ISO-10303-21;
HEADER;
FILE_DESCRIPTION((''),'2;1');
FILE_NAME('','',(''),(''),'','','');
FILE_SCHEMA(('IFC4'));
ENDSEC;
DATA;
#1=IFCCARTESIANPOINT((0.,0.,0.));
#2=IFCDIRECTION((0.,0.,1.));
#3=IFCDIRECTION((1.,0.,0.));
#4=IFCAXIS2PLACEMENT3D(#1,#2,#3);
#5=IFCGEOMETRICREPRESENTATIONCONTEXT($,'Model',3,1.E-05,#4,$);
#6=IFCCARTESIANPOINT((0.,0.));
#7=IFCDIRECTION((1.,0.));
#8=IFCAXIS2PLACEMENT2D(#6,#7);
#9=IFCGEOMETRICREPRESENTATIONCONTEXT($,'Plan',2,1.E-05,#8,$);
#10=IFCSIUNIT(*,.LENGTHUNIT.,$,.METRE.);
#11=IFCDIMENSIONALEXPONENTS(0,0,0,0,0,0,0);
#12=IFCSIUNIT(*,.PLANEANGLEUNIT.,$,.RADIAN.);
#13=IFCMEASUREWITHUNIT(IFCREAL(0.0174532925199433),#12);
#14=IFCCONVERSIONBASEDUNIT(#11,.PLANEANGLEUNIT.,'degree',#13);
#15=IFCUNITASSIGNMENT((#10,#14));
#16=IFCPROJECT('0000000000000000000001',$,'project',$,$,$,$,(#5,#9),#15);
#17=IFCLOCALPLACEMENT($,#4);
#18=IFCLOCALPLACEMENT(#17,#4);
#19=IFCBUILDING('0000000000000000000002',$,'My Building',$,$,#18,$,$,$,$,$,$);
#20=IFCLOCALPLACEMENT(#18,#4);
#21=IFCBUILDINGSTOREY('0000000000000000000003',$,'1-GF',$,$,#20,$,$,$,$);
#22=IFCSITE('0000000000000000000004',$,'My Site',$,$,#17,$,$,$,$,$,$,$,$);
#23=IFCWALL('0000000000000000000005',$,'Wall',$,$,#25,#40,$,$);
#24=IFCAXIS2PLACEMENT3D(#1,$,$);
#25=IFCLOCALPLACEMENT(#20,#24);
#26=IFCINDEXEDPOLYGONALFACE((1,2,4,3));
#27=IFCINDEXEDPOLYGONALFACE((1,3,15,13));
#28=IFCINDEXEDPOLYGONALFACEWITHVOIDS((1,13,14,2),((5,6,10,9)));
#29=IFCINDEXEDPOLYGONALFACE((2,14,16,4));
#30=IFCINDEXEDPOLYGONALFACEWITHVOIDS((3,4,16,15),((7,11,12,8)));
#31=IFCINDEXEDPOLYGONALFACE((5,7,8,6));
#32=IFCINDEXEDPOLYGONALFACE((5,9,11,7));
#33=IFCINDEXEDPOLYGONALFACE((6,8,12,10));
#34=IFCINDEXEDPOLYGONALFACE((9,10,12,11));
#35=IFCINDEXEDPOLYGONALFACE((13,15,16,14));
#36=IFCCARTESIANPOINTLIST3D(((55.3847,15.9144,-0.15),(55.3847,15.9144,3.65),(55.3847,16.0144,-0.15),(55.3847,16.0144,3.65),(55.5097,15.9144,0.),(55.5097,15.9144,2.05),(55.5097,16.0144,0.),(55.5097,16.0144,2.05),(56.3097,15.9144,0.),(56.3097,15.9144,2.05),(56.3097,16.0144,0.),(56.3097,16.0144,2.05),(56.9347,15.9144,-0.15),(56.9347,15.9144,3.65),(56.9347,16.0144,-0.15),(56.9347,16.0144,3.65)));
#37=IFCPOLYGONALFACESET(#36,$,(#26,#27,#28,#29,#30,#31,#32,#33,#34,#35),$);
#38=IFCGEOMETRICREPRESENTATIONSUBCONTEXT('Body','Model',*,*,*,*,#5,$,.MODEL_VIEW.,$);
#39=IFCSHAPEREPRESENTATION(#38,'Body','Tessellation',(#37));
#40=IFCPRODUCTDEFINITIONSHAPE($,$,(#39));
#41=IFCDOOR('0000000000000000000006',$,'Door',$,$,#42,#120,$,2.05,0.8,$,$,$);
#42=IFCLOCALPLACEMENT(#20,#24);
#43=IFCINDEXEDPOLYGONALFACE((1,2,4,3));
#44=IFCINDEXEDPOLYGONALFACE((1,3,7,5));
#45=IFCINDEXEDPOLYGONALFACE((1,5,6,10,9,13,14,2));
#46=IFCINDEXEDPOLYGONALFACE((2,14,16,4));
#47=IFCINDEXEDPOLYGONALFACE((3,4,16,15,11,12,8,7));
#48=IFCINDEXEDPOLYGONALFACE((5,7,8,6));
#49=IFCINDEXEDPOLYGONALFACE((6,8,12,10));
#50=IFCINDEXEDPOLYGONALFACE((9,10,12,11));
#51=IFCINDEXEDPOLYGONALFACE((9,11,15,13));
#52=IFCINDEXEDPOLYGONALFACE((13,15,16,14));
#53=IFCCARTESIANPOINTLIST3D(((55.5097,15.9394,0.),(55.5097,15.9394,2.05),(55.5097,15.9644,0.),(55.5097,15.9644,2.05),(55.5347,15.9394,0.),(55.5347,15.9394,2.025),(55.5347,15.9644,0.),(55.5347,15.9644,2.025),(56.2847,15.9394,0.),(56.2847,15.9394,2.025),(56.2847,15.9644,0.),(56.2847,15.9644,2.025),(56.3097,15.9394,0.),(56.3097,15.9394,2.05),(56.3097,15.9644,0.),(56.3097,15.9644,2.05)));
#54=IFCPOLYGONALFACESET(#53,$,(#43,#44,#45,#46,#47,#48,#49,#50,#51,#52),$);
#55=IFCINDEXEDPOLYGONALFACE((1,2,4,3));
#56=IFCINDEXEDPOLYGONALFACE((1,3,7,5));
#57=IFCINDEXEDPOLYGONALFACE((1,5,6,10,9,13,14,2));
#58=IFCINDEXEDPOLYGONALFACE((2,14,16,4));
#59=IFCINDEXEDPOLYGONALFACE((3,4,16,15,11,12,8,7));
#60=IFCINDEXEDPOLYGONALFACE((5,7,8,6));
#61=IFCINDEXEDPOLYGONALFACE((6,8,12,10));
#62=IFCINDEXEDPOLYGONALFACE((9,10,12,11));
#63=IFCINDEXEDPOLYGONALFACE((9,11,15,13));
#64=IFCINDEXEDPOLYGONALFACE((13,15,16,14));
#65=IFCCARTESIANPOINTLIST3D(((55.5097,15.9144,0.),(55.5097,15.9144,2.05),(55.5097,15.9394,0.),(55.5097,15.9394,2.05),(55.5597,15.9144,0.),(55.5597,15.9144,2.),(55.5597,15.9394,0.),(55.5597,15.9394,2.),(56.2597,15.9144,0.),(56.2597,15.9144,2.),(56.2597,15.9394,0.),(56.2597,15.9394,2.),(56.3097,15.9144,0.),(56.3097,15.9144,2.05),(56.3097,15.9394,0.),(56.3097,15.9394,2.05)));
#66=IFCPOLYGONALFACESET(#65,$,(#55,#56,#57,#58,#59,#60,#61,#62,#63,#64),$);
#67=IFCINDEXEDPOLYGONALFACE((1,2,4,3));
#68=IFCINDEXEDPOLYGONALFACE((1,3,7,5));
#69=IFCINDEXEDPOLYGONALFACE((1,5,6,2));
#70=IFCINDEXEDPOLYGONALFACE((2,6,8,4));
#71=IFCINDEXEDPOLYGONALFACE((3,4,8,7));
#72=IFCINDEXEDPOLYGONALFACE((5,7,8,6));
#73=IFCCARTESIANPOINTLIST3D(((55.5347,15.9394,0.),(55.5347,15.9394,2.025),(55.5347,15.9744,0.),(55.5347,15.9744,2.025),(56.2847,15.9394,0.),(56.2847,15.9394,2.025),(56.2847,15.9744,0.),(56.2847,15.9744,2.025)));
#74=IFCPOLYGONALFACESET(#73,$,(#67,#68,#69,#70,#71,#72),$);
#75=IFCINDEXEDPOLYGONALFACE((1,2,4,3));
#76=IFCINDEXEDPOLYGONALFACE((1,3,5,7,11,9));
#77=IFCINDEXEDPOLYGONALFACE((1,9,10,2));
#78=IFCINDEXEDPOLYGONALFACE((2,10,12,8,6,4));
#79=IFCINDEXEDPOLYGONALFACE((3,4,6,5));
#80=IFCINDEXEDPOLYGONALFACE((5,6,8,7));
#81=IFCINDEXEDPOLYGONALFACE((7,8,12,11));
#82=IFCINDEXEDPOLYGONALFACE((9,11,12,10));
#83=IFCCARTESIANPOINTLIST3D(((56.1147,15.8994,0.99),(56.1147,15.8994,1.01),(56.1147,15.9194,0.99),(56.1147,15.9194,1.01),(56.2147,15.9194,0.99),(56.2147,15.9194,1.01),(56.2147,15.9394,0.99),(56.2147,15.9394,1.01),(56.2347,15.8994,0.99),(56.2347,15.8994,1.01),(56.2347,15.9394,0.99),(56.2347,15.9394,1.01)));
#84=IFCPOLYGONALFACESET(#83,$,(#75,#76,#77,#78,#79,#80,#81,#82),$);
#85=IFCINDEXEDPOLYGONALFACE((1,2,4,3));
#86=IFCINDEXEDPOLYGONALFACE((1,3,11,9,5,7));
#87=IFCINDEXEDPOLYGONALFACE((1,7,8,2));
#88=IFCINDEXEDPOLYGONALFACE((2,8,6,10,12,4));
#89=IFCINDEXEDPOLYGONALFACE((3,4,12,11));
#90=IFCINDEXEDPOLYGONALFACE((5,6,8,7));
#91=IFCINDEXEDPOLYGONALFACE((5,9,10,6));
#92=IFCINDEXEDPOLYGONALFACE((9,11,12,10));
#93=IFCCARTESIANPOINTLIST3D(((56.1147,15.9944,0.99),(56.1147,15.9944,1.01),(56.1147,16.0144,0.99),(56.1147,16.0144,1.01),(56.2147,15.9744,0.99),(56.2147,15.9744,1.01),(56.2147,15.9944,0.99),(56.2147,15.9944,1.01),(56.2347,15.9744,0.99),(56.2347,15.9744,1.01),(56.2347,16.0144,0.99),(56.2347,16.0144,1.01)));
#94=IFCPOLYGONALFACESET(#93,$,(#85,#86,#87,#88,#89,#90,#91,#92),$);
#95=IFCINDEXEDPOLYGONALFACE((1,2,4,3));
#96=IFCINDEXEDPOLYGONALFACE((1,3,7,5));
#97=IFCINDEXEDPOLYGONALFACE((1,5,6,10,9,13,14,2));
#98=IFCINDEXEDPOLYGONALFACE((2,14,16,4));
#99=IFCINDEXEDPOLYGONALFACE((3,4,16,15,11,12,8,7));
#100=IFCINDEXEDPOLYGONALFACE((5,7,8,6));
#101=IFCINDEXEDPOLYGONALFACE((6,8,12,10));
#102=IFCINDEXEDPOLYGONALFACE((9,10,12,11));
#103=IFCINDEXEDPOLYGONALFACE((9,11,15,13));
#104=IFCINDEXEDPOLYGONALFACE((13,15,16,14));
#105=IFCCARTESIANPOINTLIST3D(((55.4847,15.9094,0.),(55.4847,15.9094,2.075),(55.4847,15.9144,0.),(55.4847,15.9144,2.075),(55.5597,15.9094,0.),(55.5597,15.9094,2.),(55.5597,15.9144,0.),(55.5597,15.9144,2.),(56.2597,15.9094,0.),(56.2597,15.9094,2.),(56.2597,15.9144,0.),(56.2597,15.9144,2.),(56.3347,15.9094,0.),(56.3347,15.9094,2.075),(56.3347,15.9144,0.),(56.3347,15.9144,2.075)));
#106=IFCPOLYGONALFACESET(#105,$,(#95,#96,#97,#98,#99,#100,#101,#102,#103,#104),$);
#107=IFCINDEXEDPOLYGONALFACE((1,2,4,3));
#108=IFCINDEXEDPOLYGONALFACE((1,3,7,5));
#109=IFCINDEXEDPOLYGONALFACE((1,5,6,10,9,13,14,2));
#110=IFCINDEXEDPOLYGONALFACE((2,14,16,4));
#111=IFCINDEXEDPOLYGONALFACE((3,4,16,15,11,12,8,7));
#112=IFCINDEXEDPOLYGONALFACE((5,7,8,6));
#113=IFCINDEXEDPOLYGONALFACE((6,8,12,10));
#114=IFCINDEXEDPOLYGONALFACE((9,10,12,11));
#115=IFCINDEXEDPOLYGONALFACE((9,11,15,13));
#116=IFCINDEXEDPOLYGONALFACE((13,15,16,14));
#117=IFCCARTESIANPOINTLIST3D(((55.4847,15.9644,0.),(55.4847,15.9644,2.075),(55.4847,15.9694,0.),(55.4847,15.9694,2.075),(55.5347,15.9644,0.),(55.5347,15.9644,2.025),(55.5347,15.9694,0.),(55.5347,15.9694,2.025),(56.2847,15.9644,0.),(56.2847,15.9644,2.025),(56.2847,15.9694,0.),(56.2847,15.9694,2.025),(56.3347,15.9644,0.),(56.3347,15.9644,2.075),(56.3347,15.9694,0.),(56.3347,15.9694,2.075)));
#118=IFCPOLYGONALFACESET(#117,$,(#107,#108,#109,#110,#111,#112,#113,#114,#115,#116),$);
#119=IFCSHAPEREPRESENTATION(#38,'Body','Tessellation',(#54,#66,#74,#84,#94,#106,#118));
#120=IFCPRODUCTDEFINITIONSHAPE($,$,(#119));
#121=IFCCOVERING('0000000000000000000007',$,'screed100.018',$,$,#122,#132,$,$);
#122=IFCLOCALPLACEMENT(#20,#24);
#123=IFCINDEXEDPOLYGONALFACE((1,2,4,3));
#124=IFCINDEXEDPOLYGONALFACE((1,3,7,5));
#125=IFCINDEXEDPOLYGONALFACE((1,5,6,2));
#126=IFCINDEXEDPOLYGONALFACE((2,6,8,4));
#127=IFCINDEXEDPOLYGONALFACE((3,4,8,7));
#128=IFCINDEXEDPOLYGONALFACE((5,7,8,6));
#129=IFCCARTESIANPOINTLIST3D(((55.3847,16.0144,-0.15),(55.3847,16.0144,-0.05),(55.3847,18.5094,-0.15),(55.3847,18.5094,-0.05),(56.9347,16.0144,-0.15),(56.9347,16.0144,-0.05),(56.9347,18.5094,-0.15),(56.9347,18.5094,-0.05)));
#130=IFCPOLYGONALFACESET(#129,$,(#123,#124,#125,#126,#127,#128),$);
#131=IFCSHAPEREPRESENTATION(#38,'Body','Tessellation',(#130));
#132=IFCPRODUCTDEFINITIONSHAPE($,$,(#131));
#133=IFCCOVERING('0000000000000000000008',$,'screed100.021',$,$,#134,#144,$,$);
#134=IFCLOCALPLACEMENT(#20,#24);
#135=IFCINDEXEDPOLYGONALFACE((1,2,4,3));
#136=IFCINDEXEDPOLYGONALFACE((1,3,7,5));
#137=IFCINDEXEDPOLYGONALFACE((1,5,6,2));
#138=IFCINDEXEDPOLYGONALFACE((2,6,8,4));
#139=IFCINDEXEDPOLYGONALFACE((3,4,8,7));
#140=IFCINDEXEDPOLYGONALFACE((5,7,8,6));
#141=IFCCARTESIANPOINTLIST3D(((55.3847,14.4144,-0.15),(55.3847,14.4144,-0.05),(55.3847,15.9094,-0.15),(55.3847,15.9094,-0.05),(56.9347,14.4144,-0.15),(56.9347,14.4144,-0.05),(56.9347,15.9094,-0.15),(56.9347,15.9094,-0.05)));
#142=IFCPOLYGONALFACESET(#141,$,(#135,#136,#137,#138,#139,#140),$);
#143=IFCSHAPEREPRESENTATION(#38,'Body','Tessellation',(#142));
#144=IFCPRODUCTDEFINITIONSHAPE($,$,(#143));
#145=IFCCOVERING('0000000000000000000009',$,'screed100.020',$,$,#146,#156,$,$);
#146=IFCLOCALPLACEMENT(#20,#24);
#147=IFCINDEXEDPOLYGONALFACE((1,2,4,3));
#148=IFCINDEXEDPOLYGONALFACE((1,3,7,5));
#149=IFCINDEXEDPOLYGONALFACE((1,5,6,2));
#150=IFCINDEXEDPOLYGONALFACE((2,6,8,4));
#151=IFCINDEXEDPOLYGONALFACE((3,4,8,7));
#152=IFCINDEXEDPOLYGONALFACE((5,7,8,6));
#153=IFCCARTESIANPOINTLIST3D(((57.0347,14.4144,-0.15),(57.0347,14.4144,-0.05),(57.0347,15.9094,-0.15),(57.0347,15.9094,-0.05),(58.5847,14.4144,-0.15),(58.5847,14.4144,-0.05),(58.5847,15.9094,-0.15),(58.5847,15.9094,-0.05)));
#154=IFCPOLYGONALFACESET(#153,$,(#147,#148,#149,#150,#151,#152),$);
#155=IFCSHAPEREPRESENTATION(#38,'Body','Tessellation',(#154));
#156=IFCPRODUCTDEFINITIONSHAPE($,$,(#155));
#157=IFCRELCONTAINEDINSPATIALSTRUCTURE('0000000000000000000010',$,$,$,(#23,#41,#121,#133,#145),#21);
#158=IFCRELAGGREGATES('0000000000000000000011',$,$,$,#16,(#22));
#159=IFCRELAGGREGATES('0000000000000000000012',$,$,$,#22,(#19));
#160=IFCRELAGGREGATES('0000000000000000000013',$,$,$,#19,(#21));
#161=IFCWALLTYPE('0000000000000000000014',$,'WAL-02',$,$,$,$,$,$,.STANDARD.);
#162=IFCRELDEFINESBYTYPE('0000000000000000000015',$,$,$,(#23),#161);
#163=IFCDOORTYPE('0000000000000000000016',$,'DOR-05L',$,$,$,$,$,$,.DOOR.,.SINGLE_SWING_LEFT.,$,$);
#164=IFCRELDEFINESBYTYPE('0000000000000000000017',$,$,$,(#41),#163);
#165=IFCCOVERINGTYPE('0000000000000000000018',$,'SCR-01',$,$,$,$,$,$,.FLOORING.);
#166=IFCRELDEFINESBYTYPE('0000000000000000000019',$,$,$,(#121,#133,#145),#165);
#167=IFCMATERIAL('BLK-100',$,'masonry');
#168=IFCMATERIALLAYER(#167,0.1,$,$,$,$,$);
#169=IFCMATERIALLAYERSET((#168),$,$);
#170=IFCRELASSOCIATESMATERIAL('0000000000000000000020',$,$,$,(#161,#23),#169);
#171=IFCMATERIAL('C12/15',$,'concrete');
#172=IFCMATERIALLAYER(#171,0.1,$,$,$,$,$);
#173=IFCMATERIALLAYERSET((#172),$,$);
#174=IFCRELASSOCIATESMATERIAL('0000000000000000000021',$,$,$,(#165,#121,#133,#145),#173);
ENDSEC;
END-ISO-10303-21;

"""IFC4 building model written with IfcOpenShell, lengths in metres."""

from ifc_helpers import new_model, entity, si_unit, converted_unit, frame, origin_with_axes, origin_2d_with_axis, place, context, subcontext, project, spatial, line, indexed_curve, outline, extrude, shape, source, transform, mapped, material, layer, layer_set, layer_usage, type_object, type_shapes, element, fill, save


model = new_model("IFC4")

# Units and contexts
model_context = context("Model", 3, precision=1e-05, world=origin_with_axes())
plan_context = context("Plan", 2, precision=1e-05, world=origin_2d_with_axis())
body_context_1 = subcontext(model_context, "Body", "Model", "MODEL_VIEW")
body_context_2 = subcontext(plan_context, "Body", "Plan", "PLAN_VIEW")
ifc_project = project(units=[si_unit("LENGTHUNIT", "METRE"), converted_unit("PLANEANGLEUNIT", "degree", entity("IfcReal", 0.0174532925199433), si_unit("PLANEANGLEUNIT", "RADIAN"), dimensions=[0, 0, 0, 0, 0, 0, 0])], contexts=[model_context, plan_context])

# Site, building, storey
site_placement = place(None, origin_with_axes())
site = spatial("IfcSite", under=ifc_project, at=site_placement, Name="My Site")
building_placement = place(site_placement, origin_with_axes())
building = spatial("IfcBuilding", under=site, at=building_placement, Name="My Building")
storey_placement = place(building_placement, origin_with_axes())
storey = spatial("IfcBuildingStorey", under=building, at=storey_placement, Name="1-GF")

# Shared definitions
ifc_material_1 = material(Name="BLK-100", Category="masonry")
ifc_layer_1 = layer(ifc_material_1, 0.1)
ifc_layer_set_1 = layer_set([ifc_layer_1])
wall_type_1 = type_object("IfcWallType", Name="WAL-02", PredefinedType="STANDARD", material=ifc_layer_set_1)

# Wall, opening, door
ifc_layer_usage_1 = layer_usage(ifc_layer_set_1, "AXIS2", "POSITIVE", 0.0)
wall_1_placement = place(storey_placement, frame((55.3847, 15.9144, -0.15), z_axis=(0.0, 0.0, 1.0), x_axis=(1.0, 0.0, 0.0)))
wall_1 = element("IfcWall", 1, at=wall_1_placement, inside=storey, type_object=wall_type_1, material=ifc_layer_usage_1, Name="Wall", context=body_context_1, shape_type="SweptSolid", body=[
    extrude(outline(indexed_curve([(0.0, 0.0), (0.0, 0.1), (1.55, 0.1), (1.55, 0.0), (0.0, 0.0)], self_intersect=False)), origin_with_axes(), (0.0, 0.0, 1.0), 3.8),
])
shared_shape_1 = source(origin_with_axes(), body_context_1, "Body", "SweptSolid", [
    extrude(outline(indexed_curve([(0.0, 0.0), (0.8, 0.0), (0.8, 2.05), (0.0, 2.05)], segments=[line(1, 2, 3, 4, 1)])), frame((0.0, -0.1, 0.0), z_axis=(0.0, -1.0, 0.0), x_axis=(1.0, 0.0, 0.0)), (0.0, 0.0, -1.0), 0.3),
])
opening_1_placement = place(wall_1_placement, frame((0.125, 0.0, 0.15), z_axis=(0.0, 0.0, 1.0), x_axis=(1.0, 0.0, 0.0)))
opening_1 = element("IfcOpeningElement", 2, at=opening_1_placement, cuts=wall_1, PredefinedType="OPENING", context=body_context_1, shape_type="MappedRepresentation", body=[
    mapped(shared_shape_1, transform((0.0, 0.0, 0.0), x_axis=(1.0, 0.0, 0.0), y_axis=(0.0, 1.0, 0.0), z_axis=(0.0, 0.0, 1.0), scale=1.0)),
])
door_type_1 = type_object("IfcDoorType", Name="DOR-05L", OperationType="SINGLE_SWING_LEFT", PredefinedType="DOOR")
shared_shape_2 = source(origin_with_axes(), body_context_1, "Body", "SweptSolid", [
    extrude(outline(indexed_curve([(0.0, 0.0), (0.0, 2.05), (0.8, 2.05), (0.8, 0.0), (0.775, 0.0), (0.775, 2.025), (0.025, 2.025), (0.025, 0.0)], segments=[line(1, 2, 3, 4, 5, 6, 7, 8, 1)])), frame((0.0, 0.025, 0.0), z_axis=(0.0, -1.0, 0.0), x_axis=(1.0, 0.0, 0.0)), (0.0, 0.0, -1.0), 0.025),
    extrude(outline(indexed_curve([(0.0, 0.0), (0.0, 2.05), (0.8, 2.05), (0.8, 0.0), (0.75, 0.0), (0.75, 2.0), (0.05, 2.0), (0.05, 0.0)], segments=[line(1, 2, 3, 4, 5, 6, 7, 8, 1)])), frame((0.0, 0.0, 0.0), z_axis=(0.0, -1.0, 0.0), x_axis=(1.0, 0.0, 0.0)), (0.0, 0.0, -1.0), 0.025),
    extrude(outline(indexed_curve([(0.0, 0.0), (0.75, 0.0), (0.75, 0.035), (0.0, 0.035)], segments=[line(1, 2, 3, 4, 1)])), frame((0.025, 0.025, 0.0), z_axis=(0.0, 0.0, 1.0), x_axis=(1.0, 0.0, 0.0)), (0.0, 0.0, 1.0), 2.025),
    extrude(outline(indexed_curve([(0.0, 0.0), (0.0, -0.04), (-0.12, -0.04), (-0.12, -0.02), (-0.02, -0.02), (-0.02, 0.0)], segments=[line(1, 2, 3, 4, 5, 6, 1)])), frame((0.725, 0.025, 0.99), z_axis=(0.0, 0.0, 1.0), x_axis=(1.0, 0.0, 0.0)), (0.0, 0.0, 1.0), 0.02),
    extrude(outline(indexed_curve([(0.0, 0.0), (0.0, 0.04), (-0.12, 0.04), (-0.12, 0.02), (-0.02, 0.02), (-0.02, 0.0)], segments=[line(1, 2, 3, 4, 5, 6, 1)])), frame((0.725, 0.06, 0.99), z_axis=(0.0, 0.0, 1.0), x_axis=(1.0, 0.0, 0.0)), (0.0, 0.0, 1.0), 0.02),
    extrude(outline(indexed_curve([(0.0, 0.0), (0.0, 2.075), (0.85, 2.075), (0.85, 0.0), (0.775, 0.0), (0.775, 2.0), (0.075, 2.0), (0.075, 0.0)], segments=[line(1, 2, 3, 4, 5, 6, 7, 8, 1)])), frame((-0.025, -0.005, 0.0), z_axis=(0.0, -1.0, 0.0), x_axis=(1.0, 0.0, 0.0)), (0.0, 0.0, -1.0), 0.005),
    extrude(outline(indexed_curve([(0.0, 0.0), (0.0, 2.075), (0.85, 2.075), (0.85, 0.0), (0.8, 0.0), (0.8, 2.025), (0.05, 2.025), (0.05, 0.0)], segments=[line(1, 2, 3, 4, 5, 6, 7, 8, 1)])), frame((-0.025, 0.05, 0.0), z_axis=(0.0, -1.0, 0.0), x_axis=(1.0, 0.0, 0.0)), (0.0, 0.0, -1.0), 0.005),
])
shared_shape_3 = source(origin_with_axes(), body_context_2, "Body", "Curve2D", [
    entity("IfcIndexedPolyCurve", entity("IfcCartesianPointList2D", [[0.0, 0.0], [0.0, 0.05], [0.025, 0.05], [0.025, 0.025], [0.05, 0.025], [0.05, 0.0]]), [entity("IfcLineIndex", [1, 2, 3, 4, 5, 6, 1])]),
    entity("IfcIndexedPolyCurve", entity("IfcCartesianPointList2D", [[0.8, 0.0], [0.8, 0.05], [0.775, 0.05], [0.775, 0.025], [0.75, 0.025], [0.75, 0.0]]), [entity("IfcLineIndex", [1, 2, 3, 4, 5, 6, 1])]),
    entity("IfcTrimmedCurve", entity("IfcEllipse", entity("IfcAxis2Placement2D", entity("IfcCartesianPoint", [0.06, 0.05]), entity("IfcDirection", [1.0, 0.0])), 0.715, 0.75), [entity("IfcCartesianPoint", [0.775, 0.05])], [entity("IfcCartesianPoint", [0.06, 0.8])], True, "CARTESIAN"),
    entity("IfcIndexedPolyCurve", entity("IfcCartesianPointList2D", [[0.025, 0.05], [0.06, 0.05], [0.06, 0.8], [0.025, 0.8]]), [entity("IfcLineIndex", [1, 2, 3, 4, 1])]),
])
type_shapes(door_type_1, [shared_shape_2, shared_shape_3])
door_1_placement = place(opening_1_placement, frame((0.0, 0.0, 0.0), z_axis=(0.0, 0.0, 1.0), x_axis=(1.0, 0.0, 0.0)))
door_1 = element("IfcDoor", 3, at=door_1_placement, inside=storey, type_object=door_type_1, Name="Door", OverallHeight=2.05, OverallWidth=0.8, shapes=[
    shape(body_context_1, "Body", "MappedRepresentation", [mapped(shared_shape_2, transform((0.0, 0.0, 0.0), x_axis=(1.0, 0.0, 0.0), y_axis=(0.0, 1.0, 0.0), z_axis=(0.0, 0.0, 1.0), scale=1.0))]),
    shape(body_context_2, "Body", "MappedRepresentation", [mapped(shared_shape_3, transform((0.0, 0.0, 0.0), x_axis=(1.0, 0.0, 0.0), y_axis=(0.0, 1.0, 0.0), z_axis=(0.0, 0.0, 1.0), scale=1.0))]),
])
fill(opening_1, door_1)

# Coverings
ifc_material_2 = material(Name="C12/15", Category="concrete")
ifc_layer_2 = layer(ifc_material_2, 0.1)
ifc_layer_set_2 = layer_set([ifc_layer_2])
ifc_layer_usage_2 = layer_usage(ifc_layer_set_2, "AXIS3", "POSITIVE", 0.0)
covering_type_1 = type_object("IfcCoveringType", Name="SCR-01", PredefinedType="FLOORING", material=ifc_layer_set_2)
covering_1_placement = place(storey_placement, frame((55.3847, 16.0144, -0.15), z_axis=(0.0, 0.0, 1.0), x_axis=(1.0, 0.0, 0.0)))
element("IfcCovering", 4, at=covering_1_placement, inside=storey, type_object=covering_type_1, material=ifc_layer_usage_2, Name="screed100.018", context=body_context_1, shape_type="SweptSolid", body=[
    extrude(outline(indexed_curve([(0.0, 0.0), (1.55, 0.0), (1.55, 2.495), (0.0, 2.495)], segments=[line(3, 2), line(2, 1), line(1, 4), line(4, 3)], self_intersect=False)), None, (0.0, 0.0, 1.0), 0.1),
])
ifc_layer_usage_3 = layer_usage(ifc_layer_set_2, "AXIS3", "POSITIVE", 0.0)
covering_2_placement = place(storey_placement, frame((55.3847, 14.4144, -0.15), z_axis=(0.0, 0.0, 1.0), x_axis=(1.0, 0.0, 0.0)))
element("IfcCovering", 5, at=covering_2_placement, inside=storey, type_object=covering_type_1, material=ifc_layer_usage_3, Name="screed100.021", context=body_context_1, shape_type="SweptSolid", body=[
    extrude(outline(indexed_curve([(1.55, 1.495), (1.55, 0.0), (0.0, 0.0), (0.0, 1.495)], segments=[line(4, 1), line(1, 2), line(2, 3), line(3, 4)], self_intersect=False)), None, (0.0, 0.0, 1.0), 0.1),
])
ifc_layer_usage_4 = layer_usage(ifc_layer_set_2, "AXIS3", "POSITIVE", 0.0)
covering_3_placement = place(storey_placement, frame((57.0347, 14.4144, -0.15), z_axis=(0.0, 0.0, 1.0), x_axis=(1.0, 0.0, 0.0)))
element("IfcCovering", 6, at=covering_3_placement, inside=storey, type_object=covering_type_1, material=ifc_layer_usage_4, Name="screed100.020", context=body_context_1, shape_type="SweptSolid", body=[
    extrude(outline(indexed_curve([(1.55, 1.495), (1.55, 0.0), (0.0, 0.0), (0.0, 1.495)], segments=[line(4, 1), line(1, 2), line(2, 3), line(3, 4)], self_intersect=False)), None, (0.0, 0.0, 1.0), 0.1),
])

save(model, "model.ifc")
